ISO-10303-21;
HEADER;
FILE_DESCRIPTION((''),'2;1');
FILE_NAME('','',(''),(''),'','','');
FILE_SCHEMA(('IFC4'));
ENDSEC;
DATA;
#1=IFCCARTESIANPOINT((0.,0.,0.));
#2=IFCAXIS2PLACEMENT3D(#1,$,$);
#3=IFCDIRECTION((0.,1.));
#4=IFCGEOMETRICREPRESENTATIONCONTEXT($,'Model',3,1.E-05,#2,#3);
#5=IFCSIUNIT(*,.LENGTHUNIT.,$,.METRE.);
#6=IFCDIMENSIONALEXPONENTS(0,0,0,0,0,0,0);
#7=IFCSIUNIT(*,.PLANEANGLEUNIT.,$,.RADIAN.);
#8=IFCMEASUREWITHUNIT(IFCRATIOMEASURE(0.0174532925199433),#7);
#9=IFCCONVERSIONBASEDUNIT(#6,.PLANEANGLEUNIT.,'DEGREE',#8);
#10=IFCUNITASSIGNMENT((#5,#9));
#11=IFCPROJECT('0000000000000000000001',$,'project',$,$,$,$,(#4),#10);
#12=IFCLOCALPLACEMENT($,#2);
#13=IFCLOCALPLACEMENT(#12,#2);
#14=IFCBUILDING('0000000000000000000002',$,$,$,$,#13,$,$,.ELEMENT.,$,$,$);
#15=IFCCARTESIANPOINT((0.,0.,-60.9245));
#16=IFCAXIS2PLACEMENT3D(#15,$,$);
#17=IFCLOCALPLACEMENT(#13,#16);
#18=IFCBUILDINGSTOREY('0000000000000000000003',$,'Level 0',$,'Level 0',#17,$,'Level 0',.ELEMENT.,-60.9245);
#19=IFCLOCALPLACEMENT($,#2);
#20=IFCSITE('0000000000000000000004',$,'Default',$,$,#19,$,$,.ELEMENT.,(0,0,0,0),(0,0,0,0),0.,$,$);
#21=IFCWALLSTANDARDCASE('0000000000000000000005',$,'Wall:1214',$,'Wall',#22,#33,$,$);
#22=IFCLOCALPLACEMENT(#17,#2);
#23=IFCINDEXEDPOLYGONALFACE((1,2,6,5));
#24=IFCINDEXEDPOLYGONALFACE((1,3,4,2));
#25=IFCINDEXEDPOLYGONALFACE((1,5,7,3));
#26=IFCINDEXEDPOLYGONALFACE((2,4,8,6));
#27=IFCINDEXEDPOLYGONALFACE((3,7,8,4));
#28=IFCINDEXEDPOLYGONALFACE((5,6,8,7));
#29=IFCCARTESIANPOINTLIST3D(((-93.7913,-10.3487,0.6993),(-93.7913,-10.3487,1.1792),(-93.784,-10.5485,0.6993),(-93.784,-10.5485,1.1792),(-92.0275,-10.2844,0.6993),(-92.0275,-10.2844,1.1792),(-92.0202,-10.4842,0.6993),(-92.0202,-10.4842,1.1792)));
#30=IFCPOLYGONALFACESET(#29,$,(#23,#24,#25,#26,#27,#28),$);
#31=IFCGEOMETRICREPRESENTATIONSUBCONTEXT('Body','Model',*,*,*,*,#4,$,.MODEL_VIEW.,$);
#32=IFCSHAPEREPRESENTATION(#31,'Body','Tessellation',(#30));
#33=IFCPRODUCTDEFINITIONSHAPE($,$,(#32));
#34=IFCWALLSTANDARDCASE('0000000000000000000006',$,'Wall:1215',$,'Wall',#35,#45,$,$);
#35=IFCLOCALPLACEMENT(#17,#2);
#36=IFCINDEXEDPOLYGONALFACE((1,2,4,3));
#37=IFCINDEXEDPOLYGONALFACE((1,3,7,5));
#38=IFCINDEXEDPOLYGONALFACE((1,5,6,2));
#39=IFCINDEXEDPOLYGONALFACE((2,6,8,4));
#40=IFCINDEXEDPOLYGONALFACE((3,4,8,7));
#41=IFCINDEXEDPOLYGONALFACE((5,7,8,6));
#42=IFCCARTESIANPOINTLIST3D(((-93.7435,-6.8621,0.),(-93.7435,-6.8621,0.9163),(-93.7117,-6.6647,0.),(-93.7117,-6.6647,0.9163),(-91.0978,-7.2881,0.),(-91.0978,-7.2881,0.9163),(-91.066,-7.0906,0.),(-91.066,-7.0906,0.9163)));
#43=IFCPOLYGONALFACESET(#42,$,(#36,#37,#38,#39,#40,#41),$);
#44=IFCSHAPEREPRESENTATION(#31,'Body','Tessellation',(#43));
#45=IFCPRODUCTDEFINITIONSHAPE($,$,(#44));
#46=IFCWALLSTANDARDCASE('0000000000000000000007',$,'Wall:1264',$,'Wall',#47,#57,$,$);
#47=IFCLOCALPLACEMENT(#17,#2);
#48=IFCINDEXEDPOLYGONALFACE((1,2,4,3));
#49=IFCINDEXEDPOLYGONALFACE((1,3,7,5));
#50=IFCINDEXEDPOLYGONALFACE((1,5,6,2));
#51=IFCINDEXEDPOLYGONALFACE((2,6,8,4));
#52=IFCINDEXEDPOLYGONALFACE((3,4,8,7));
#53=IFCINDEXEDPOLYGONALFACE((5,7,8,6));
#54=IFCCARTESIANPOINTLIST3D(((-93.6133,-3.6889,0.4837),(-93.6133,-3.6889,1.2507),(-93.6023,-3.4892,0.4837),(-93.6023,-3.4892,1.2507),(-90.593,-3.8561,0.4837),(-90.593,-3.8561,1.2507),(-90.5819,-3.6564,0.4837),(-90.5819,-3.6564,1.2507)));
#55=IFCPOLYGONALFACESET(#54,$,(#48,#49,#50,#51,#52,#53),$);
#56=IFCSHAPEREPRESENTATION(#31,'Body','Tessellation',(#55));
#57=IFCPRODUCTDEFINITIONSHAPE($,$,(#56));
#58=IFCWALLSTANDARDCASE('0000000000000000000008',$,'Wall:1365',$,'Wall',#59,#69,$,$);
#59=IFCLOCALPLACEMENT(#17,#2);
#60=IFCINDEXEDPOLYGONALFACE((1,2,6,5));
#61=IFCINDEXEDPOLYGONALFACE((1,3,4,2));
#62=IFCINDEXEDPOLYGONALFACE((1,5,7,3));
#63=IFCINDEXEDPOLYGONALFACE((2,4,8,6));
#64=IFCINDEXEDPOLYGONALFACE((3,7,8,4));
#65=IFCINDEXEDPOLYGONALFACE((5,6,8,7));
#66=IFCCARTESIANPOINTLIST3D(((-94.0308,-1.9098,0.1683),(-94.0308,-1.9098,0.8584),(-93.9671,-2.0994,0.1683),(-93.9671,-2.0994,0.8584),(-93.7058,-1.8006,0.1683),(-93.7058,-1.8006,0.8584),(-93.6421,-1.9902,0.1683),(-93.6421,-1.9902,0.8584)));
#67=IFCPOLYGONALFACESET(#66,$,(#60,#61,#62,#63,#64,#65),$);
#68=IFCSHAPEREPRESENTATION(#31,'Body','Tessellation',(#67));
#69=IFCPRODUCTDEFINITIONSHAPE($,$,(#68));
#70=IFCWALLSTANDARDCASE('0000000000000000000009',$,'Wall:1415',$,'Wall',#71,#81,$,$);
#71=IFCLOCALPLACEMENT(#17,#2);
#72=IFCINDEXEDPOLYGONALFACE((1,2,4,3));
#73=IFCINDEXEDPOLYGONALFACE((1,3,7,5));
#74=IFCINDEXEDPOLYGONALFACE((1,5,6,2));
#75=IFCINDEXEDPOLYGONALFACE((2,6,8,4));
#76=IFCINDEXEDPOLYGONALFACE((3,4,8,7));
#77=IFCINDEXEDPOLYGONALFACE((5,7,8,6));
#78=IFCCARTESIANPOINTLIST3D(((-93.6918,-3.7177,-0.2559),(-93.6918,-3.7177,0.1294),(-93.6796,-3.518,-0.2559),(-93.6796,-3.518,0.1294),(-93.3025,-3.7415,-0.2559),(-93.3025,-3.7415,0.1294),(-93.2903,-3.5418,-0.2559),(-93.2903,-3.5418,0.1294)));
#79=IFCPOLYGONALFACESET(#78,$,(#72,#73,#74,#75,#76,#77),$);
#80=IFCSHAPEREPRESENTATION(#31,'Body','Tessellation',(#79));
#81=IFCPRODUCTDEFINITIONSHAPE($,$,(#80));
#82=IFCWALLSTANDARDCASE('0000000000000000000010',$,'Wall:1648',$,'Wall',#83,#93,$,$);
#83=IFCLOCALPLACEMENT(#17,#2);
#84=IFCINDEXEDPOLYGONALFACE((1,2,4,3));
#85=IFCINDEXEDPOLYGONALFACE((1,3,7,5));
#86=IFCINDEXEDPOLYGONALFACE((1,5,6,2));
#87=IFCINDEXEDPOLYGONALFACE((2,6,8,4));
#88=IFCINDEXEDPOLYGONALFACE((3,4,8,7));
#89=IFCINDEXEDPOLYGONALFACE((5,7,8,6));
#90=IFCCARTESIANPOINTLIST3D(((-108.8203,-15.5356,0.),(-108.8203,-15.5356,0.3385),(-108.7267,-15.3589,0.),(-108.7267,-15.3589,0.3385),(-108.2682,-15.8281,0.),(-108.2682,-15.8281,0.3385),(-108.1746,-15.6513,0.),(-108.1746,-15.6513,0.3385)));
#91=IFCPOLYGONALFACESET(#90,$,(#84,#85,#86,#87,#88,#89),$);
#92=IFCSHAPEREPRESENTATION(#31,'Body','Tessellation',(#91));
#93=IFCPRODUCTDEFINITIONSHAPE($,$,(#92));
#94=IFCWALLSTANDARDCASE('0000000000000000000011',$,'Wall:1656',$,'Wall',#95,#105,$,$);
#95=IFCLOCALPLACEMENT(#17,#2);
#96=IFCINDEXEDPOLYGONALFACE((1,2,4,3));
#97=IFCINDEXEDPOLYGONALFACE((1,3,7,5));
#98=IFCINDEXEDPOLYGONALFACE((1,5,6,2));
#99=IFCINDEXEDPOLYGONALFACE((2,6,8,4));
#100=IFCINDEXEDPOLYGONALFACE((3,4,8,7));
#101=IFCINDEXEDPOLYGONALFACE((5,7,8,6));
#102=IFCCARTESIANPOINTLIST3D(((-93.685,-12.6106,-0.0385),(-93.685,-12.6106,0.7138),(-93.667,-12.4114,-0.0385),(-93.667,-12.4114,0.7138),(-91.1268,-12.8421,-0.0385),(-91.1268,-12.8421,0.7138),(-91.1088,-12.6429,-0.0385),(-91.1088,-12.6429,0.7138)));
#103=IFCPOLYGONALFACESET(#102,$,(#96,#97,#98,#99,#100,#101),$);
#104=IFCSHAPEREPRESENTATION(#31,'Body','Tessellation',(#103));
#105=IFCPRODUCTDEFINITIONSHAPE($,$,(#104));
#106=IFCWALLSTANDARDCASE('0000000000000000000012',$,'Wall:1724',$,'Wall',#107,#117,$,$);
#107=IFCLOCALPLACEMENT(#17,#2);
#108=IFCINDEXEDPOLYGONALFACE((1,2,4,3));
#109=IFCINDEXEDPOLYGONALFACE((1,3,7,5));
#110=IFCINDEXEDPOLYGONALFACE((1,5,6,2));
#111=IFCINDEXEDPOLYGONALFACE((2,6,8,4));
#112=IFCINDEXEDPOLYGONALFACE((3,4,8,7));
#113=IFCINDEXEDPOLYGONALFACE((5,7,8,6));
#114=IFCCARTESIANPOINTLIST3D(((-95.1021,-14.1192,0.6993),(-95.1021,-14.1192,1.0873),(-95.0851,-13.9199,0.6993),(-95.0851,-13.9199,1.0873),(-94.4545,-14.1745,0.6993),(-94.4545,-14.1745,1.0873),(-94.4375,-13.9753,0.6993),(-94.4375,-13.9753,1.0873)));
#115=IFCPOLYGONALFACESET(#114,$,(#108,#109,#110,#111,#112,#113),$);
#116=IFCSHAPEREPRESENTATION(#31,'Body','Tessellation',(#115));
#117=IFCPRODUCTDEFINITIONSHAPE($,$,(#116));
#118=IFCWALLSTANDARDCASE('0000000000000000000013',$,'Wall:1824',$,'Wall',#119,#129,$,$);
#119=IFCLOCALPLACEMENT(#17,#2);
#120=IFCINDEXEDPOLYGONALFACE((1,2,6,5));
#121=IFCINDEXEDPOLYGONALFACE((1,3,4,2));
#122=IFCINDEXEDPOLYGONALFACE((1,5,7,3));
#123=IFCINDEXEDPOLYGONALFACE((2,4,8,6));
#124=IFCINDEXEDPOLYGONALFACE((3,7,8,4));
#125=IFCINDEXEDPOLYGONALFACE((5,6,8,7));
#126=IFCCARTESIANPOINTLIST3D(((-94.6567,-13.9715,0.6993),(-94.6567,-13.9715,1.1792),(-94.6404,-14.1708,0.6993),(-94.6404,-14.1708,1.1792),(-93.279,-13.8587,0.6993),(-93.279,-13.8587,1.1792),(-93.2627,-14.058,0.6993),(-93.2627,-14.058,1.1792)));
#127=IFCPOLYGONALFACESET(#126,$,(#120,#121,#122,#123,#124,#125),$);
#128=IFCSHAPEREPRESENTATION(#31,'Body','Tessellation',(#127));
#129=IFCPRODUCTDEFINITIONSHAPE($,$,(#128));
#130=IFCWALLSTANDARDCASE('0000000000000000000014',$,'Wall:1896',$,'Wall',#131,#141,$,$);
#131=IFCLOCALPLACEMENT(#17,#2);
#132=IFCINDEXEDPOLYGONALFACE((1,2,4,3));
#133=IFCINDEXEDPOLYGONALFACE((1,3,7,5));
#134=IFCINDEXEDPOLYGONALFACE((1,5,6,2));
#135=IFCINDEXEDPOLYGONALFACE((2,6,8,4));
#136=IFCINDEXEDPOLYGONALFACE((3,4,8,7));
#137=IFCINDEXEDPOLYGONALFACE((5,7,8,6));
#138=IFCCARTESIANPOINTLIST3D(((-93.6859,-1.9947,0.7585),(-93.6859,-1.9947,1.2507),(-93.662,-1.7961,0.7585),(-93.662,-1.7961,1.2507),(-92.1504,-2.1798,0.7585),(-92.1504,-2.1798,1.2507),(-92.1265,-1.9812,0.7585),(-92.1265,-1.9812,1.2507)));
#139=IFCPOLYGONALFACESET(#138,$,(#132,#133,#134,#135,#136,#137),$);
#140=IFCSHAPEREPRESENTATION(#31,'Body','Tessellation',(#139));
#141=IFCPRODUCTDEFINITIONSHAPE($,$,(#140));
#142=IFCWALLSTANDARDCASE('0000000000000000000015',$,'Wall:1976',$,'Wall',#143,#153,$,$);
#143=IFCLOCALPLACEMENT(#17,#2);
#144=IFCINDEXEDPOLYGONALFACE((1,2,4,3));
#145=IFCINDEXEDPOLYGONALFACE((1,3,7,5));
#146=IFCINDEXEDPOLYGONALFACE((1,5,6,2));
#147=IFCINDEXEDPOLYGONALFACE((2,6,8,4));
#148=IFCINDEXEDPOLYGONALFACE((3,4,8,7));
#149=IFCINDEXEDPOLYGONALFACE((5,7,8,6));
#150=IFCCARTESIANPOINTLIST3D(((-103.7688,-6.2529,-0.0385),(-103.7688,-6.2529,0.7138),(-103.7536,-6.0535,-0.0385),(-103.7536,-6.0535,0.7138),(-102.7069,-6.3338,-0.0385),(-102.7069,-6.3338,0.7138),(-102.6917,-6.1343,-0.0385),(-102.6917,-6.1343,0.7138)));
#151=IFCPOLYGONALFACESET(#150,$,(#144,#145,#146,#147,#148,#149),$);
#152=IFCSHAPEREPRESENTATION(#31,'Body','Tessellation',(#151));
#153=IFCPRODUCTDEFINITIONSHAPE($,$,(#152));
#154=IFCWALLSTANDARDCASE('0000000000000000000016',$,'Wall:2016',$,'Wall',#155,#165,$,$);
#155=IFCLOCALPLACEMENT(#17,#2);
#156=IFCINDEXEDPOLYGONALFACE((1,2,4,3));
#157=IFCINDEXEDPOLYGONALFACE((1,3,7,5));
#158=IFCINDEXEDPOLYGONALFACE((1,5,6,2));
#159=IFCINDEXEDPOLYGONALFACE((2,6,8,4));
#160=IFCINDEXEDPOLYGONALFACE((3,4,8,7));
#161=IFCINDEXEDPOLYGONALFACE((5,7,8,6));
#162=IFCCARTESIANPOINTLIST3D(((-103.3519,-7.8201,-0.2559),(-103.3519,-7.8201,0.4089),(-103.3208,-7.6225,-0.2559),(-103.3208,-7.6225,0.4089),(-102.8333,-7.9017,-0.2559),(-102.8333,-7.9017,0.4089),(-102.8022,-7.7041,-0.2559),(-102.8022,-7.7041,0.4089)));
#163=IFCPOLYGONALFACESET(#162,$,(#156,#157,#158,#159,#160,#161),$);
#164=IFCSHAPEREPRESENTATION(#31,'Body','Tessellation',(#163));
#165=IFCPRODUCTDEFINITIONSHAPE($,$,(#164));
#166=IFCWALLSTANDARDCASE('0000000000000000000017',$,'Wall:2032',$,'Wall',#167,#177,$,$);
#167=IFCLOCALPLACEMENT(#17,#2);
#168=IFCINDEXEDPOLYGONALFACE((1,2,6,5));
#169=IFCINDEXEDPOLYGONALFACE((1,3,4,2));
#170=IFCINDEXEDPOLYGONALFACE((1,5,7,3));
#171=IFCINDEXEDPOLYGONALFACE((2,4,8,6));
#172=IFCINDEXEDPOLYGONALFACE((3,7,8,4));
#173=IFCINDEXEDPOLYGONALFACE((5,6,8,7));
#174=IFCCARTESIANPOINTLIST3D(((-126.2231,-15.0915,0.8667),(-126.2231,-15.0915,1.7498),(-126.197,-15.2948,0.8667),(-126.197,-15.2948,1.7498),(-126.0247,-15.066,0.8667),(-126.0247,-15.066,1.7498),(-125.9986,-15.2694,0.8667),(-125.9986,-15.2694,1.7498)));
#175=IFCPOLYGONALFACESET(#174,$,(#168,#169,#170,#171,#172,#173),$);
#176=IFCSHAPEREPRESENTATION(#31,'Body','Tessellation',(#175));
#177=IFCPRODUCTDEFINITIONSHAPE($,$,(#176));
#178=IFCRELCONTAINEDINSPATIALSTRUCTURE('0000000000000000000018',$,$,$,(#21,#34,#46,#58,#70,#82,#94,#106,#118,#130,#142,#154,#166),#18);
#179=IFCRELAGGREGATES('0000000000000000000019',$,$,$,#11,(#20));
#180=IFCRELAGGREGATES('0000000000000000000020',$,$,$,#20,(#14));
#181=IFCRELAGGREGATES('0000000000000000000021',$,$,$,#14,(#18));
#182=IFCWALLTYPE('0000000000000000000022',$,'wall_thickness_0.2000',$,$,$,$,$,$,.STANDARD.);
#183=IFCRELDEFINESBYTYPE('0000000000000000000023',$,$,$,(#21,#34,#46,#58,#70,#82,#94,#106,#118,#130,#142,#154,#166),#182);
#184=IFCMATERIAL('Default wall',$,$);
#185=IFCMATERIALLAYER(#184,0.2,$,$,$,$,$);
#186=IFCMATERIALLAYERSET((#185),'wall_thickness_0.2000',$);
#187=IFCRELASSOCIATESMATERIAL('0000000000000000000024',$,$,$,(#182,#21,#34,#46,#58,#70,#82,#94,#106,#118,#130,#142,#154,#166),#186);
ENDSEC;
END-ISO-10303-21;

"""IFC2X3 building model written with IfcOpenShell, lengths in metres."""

from ifc_helpers import new_model, entity, si_unit, converted_unit, direction, frame, origin, place, context, subcontext, project, spatial, polyline, outline, extrude, material, layer, layer_set, layer_usage, type_object, element, save


model = new_model("IFC2X3")

# Units and contexts
model_context = context("Model", 3, precision=1e-05, world=origin(), true_north=direction((0.0, 1.0)))
body_context = subcontext(model_context, "Body", "Model", "MODEL_VIEW")
ifc_project = project(units=[si_unit("LENGTHUNIT", "METRE"), converted_unit("PLANEANGLEUNIT", "DEGREE", entity("IfcRatioMeasure", 0.0174532925199433), si_unit("PLANEANGLEUNIT", "RADIAN"), dimensions=[0, 0, 0, 0, 0, 0, 0])], contexts=[model_context])

# Site, building, storey
site_placement = place(None, origin())
site = spatial("IfcSite", under=ifc_project, at=site_placement, Name="Default", CompositionType="ELEMENT", RefLatitude=(0, 0, 0, 0), RefLongitude=(0, 0, 0, 0), RefElevation=0.0)
placement_1 = place(None, origin())
building_placement = place(placement_1, origin())
building = spatial("IfcBuilding", under=site, at=building_placement, CompositionType="ELEMENT")
storey_placement = place(building_placement, frame((0.0, 0.0, -60.9245)))
storey = spatial("IfcBuildingStorey", under=building, at=storey_placement, Name="Level 0", ObjectType="Level 0", LongName="Level 0", CompositionType="ELEMENT", Elevation=-60.9245)

# Walls
ifc_material = material(Name="Default wall")
ifc_layer = layer(ifc_material, 0.2)
ifc_layer_set = layer_set([ifc_layer], Name="wall_thickness_0.2000")
ifc_layer_usage = layer_usage(ifc_layer_set, "AXIS2", "POSITIVE", -0.1)
wall_type = type_object("IfcWallType", Name="wall_thickness_0.2000", PredefinedType="STANDARD", material=ifc_layer_set)
placement_2 = place(building_placement, frame((0.0, 0.0, -60.2252)))
wall_1_placement = place(placement_2, frame((-93.7877, -10.4486, 0.0), z_axis=(0.0, 0.0, 1.0), x_axis=(0.999336, 0.036426, 0.0)))
element("IfcWallStandardCase", 1, at=wall_1_placement, inside=storey, type_object=wall_type, material=ifc_layer_usage, Name="Wall:1214", ObjectType="Wall", context=body_context, shape_type="SweptSolid", body=[
    extrude(outline(polyline([(1.765, -0.1), (1.765, 0.1), (0.0, 0.1), (0.0, -0.1), (1.765, -0.1)])), origin(), (0.0, 0.0, 1.0), 0.4799),
])
wall_2_placement = place(storey_placement, frame((-93.7276, -6.7634, 0.0), z_axis=(0.0, 0.0, 1.0), x_axis=(0.987288, -0.158943, 0.0)))
element("IfcWallStandardCase", 2, at=wall_2_placement, inside=storey, type_object=wall_type, material=ifc_layer_usage, Name="Wall:1215", ObjectType="Wall", context=body_context, shape_type="SweptSolid", body=[
    extrude(outline(polyline([(2.6798, -0.1), (2.6798, 0.1), (0.0, 0.1), (0.0, -0.1), (2.6798, -0.1)])), origin(), (0.0, 0.0, 1.0), 0.9163),
])
placement_3 = place(building_placement, frame((0.0, 0.0, -60.4408)))
wall_3_placement = place(placement_3, frame((-93.6078, -3.5891, 0.0), z_axis=(0.0, 0.0, 1.0), x_axis=(0.998473, -0.055243, 0.0)))
element("IfcWallStandardCase", 3, at=wall_3_placement, inside=storey, type_object=wall_type, material=ifc_layer_usage, Name="Wall:1264", ObjectType="Wall", context=body_context, shape_type="SweptSolid", body=[
    extrude(outline(polyline([(3.025, -0.1), (3.025, 0.1), (0.0, 0.1), (0.0, -0.1), (3.025, -0.1)])), origin(), (0.0, 0.0, 1.0), 0.767),
])
placement_4 = place(building_placement, frame((0.0, 0.0, -60.7562)))
wall_4_placement = place(placement_4, frame((-93.6739, -1.8954, 0.0), z_axis=(0.0, 0.0, 1.0), x_axis=(-0.947921, -0.318505, 0.0)))
element("IfcWallStandardCase", 4, at=wall_4_placement, inside=storey, type_object=wall_type, material=ifc_layer_usage, Name="Wall:1365", ObjectType="Wall", context=body_context, shape_type="SweptSolid", body=[
    extrude(outline(polyline([(0.3429, -0.1), (0.3429, 0.1), (0.0, 0.1), (0.0, -0.1), (0.3429, -0.1)])), origin(), (0.0, 0.0, 1.0), 0.69),
])
placement_5 = place(building_placement, frame((0.0, 0.0, -61.1804)))
wall_5_placement = place(placement_5, frame((-93.2964, -3.6417, 0.0), z_axis=(0.0, 0.0, 1.0), x_axis=(-0.998136, 0.061026, 0.0)))
element("IfcWallStandardCase", 5, at=wall_5_placement, inside=storey, type_object=wall_type, material=ifc_layer_usage, Name="Wall:1415", ObjectType="Wall", context=body_context, shape_type="SweptSolid", body=[
    extrude(outline(polyline([(0.39, -0.1), (0.39, 0.1), (0.0, 0.1), (0.0, -0.1), (0.39, -0.1)])), origin(), (0.0, 0.0, 1.0), 0.3853),
])
wall_6_placement = place(storey_placement, frame((-108.7735, -15.4473, 0.0), z_axis=(0.0, 0.0, 1.0), x_axis=(0.883718, -0.46802, 0.0)))
element("IfcWallStandardCase", 6, at=wall_6_placement, inside=storey, type_object=wall_type, material=ifc_layer_usage, Name="Wall:1648", ObjectType="Wall", context=body_context, shape_type="SweptSolid", body=[
    extrude(outline(polyline([(0.6248, -0.1), (0.6248, 0.1), (0.0, 0.1), (0.0, -0.1), (0.6248, -0.1)])), origin(), (0.0, 0.0, 1.0), 0.3385),
])
placement_6 = place(building_placement, frame((0.0, 0.0, -60.963)))
wall_7_placement = place(placement_6, frame((-93.676, -12.511, 0.0), z_axis=(0.0, 0.0, 1.0), x_axis=(0.995931, -0.09012, 0.0)))
element("IfcWallStandardCase", 7, at=wall_7_placement, inside=storey, type_object=wall_type, material=ifc_layer_usage, Name="Wall:1656", ObjectType="Wall", context=body_context, shape_type="SweptSolid", body=[
    extrude(outline(polyline([(2.5687, -0.1), (2.5687, 0.1), (0.0, 0.1), (0.0, -0.1), (2.5687, -0.1)])), origin(), (0.0, 0.0, 1.0), 0.7523),
])
placement_7 = place(building_placement, frame((0.0, 0.0, -60.2252)))
wall_8_placement = place(placement_7, frame((-95.0936, -14.0195, 0.0), z_axis=(0.0, 0.0, 1.0), x_axis=(0.996364, -0.085193, 0.0)))
element("IfcWallStandardCase", 8, at=wall_8_placement, inside=storey, type_object=wall_type, material=ifc_layer_usage, Name="Wall:1724", ObjectType="Wall", context=body_context, shape_type="SweptSolid", body=[
    extrude(outline(polyline([(0.65, -0.1), (0.65, 0.1), (0.0, 0.1), (0.0, -0.1), (0.65, -0.1)])), origin(), (0.0, 0.0, 1.0), 0.3881),
])
placement_8 = place(building_placement, frame((0.0, 0.0, -60.2252)))
wall_9_placement = place(placement_8, frame((-94.6485, -14.0712, 0.0), z_axis=(0.0, 0.0, 1.0), x_axis=(0.996665, 0.081603, 0.0)))
element("IfcWallStandardCase", 9, at=wall_9_placement, inside=storey, type_object=wall_type, material=ifc_layer_usage, Name="Wall:1824", ObjectType="Wall", context=body_context, shape_type="SweptSolid", body=[
    extrude(outline(polyline([(1.3823, -0.1), (1.3823, 0.1), (0.0, 0.1), (0.0, -0.1), (1.3823, -0.1)])), origin(), (0.0, 0.0, 1.0), 0.4799),
])
placement_9 = place(building_placement, frame((0.0, 0.0, -60.166)))
wall_10_placement = place(placement_9, frame((-93.6739, -1.8954, 0.0), z_axis=(0.0, 0.0, 1.0), x_axis=(0.992815, -0.11966, 0.0)))
element("IfcWallStandardCase", 10, at=wall_10_placement, inside=storey, type_object=wall_type, material=ifc_layer_usage, Name="Wall:1896", ObjectType="Wall", context=body_context, shape_type="SweptSolid", body=[
    extrude(outline(polyline([(1.5466, -0.1), (1.5466, 0.1), (0.0, 0.1), (0.0, -0.1), (1.5466, -0.1)])), origin(), (0.0, 0.0, 1.0), 0.4922),
])
placement_10 = place(building_placement, frame((0.0, 0.0, -60.963)))
wall_11_placement = place(placement_10, frame((-103.7612, -6.1532, 0.0), z_axis=(0.0, 0.0, 1.0), x_axis=(0.997113, -0.075934, 0.0)))
element("IfcWallStandardCase", 11, at=wall_11_placement, inside=storey, type_object=wall_type, material=ifc_layer_usage, Name="Wall:1976", ObjectType="Wall", context=body_context, shape_type="SweptSolid", body=[
    extrude(outline(polyline([(1.065, -0.1), (1.065, 0.1), (0.0, 0.1), (0.0, -0.1), (1.065, -0.1)])), origin(), (0.0, 0.0, 1.0), 0.7523),
])
placement_11 = place(building_placement, frame((0.0, 0.0, -61.1804)))
wall_12_placement = place(placement_11, frame((-102.8178, -7.8029, 0.0), z_axis=(0.0, 0.0, 1.0), x_axis=(-0.98785, 0.15541, 0.0)))
element("IfcWallStandardCase", 12, at=wall_12_placement, inside=storey, type_object=wall_type, material=ifc_layer_usage, Name="Wall:2016", ObjectType="Wall", context=body_context, shape_type="SweptSolid", body=[
    extrude(outline(polyline([(0.525, -0.1), (0.525, 0.1), (0.0, 0.1), (0.0, -0.1), (0.525, -0.1)])), origin(), (0.0, 0.0, 1.0), 0.6648),
])
placement_12 = place(building_placement, frame((0.0, 0.0, -60.0578)))
wall_13_placement = place(placement_12, frame((-126.0978, -15.2821, 0.0), z_axis=(0.0, 0.0, 1.0), x_axis=(-0.127057, 0.991895, 0.0)))
element("IfcWallStandardCase", 13, at=wall_13_placement, inside=storey, type_object=wall_type, material=ifc_layer_usage, Name="Wall:2032", ObjectType="Wall", context=body_context, shape_type="SweptSolid", body=[
    extrude(outline(polyline([(0.205, -0.1), (0.205, 0.1), (0.0, 0.1), (0.0, -0.1), (0.205, -0.1)])), origin(), (0.0, 0.0, 1.0), 0.883),
])

save(model, "model.ifc")
